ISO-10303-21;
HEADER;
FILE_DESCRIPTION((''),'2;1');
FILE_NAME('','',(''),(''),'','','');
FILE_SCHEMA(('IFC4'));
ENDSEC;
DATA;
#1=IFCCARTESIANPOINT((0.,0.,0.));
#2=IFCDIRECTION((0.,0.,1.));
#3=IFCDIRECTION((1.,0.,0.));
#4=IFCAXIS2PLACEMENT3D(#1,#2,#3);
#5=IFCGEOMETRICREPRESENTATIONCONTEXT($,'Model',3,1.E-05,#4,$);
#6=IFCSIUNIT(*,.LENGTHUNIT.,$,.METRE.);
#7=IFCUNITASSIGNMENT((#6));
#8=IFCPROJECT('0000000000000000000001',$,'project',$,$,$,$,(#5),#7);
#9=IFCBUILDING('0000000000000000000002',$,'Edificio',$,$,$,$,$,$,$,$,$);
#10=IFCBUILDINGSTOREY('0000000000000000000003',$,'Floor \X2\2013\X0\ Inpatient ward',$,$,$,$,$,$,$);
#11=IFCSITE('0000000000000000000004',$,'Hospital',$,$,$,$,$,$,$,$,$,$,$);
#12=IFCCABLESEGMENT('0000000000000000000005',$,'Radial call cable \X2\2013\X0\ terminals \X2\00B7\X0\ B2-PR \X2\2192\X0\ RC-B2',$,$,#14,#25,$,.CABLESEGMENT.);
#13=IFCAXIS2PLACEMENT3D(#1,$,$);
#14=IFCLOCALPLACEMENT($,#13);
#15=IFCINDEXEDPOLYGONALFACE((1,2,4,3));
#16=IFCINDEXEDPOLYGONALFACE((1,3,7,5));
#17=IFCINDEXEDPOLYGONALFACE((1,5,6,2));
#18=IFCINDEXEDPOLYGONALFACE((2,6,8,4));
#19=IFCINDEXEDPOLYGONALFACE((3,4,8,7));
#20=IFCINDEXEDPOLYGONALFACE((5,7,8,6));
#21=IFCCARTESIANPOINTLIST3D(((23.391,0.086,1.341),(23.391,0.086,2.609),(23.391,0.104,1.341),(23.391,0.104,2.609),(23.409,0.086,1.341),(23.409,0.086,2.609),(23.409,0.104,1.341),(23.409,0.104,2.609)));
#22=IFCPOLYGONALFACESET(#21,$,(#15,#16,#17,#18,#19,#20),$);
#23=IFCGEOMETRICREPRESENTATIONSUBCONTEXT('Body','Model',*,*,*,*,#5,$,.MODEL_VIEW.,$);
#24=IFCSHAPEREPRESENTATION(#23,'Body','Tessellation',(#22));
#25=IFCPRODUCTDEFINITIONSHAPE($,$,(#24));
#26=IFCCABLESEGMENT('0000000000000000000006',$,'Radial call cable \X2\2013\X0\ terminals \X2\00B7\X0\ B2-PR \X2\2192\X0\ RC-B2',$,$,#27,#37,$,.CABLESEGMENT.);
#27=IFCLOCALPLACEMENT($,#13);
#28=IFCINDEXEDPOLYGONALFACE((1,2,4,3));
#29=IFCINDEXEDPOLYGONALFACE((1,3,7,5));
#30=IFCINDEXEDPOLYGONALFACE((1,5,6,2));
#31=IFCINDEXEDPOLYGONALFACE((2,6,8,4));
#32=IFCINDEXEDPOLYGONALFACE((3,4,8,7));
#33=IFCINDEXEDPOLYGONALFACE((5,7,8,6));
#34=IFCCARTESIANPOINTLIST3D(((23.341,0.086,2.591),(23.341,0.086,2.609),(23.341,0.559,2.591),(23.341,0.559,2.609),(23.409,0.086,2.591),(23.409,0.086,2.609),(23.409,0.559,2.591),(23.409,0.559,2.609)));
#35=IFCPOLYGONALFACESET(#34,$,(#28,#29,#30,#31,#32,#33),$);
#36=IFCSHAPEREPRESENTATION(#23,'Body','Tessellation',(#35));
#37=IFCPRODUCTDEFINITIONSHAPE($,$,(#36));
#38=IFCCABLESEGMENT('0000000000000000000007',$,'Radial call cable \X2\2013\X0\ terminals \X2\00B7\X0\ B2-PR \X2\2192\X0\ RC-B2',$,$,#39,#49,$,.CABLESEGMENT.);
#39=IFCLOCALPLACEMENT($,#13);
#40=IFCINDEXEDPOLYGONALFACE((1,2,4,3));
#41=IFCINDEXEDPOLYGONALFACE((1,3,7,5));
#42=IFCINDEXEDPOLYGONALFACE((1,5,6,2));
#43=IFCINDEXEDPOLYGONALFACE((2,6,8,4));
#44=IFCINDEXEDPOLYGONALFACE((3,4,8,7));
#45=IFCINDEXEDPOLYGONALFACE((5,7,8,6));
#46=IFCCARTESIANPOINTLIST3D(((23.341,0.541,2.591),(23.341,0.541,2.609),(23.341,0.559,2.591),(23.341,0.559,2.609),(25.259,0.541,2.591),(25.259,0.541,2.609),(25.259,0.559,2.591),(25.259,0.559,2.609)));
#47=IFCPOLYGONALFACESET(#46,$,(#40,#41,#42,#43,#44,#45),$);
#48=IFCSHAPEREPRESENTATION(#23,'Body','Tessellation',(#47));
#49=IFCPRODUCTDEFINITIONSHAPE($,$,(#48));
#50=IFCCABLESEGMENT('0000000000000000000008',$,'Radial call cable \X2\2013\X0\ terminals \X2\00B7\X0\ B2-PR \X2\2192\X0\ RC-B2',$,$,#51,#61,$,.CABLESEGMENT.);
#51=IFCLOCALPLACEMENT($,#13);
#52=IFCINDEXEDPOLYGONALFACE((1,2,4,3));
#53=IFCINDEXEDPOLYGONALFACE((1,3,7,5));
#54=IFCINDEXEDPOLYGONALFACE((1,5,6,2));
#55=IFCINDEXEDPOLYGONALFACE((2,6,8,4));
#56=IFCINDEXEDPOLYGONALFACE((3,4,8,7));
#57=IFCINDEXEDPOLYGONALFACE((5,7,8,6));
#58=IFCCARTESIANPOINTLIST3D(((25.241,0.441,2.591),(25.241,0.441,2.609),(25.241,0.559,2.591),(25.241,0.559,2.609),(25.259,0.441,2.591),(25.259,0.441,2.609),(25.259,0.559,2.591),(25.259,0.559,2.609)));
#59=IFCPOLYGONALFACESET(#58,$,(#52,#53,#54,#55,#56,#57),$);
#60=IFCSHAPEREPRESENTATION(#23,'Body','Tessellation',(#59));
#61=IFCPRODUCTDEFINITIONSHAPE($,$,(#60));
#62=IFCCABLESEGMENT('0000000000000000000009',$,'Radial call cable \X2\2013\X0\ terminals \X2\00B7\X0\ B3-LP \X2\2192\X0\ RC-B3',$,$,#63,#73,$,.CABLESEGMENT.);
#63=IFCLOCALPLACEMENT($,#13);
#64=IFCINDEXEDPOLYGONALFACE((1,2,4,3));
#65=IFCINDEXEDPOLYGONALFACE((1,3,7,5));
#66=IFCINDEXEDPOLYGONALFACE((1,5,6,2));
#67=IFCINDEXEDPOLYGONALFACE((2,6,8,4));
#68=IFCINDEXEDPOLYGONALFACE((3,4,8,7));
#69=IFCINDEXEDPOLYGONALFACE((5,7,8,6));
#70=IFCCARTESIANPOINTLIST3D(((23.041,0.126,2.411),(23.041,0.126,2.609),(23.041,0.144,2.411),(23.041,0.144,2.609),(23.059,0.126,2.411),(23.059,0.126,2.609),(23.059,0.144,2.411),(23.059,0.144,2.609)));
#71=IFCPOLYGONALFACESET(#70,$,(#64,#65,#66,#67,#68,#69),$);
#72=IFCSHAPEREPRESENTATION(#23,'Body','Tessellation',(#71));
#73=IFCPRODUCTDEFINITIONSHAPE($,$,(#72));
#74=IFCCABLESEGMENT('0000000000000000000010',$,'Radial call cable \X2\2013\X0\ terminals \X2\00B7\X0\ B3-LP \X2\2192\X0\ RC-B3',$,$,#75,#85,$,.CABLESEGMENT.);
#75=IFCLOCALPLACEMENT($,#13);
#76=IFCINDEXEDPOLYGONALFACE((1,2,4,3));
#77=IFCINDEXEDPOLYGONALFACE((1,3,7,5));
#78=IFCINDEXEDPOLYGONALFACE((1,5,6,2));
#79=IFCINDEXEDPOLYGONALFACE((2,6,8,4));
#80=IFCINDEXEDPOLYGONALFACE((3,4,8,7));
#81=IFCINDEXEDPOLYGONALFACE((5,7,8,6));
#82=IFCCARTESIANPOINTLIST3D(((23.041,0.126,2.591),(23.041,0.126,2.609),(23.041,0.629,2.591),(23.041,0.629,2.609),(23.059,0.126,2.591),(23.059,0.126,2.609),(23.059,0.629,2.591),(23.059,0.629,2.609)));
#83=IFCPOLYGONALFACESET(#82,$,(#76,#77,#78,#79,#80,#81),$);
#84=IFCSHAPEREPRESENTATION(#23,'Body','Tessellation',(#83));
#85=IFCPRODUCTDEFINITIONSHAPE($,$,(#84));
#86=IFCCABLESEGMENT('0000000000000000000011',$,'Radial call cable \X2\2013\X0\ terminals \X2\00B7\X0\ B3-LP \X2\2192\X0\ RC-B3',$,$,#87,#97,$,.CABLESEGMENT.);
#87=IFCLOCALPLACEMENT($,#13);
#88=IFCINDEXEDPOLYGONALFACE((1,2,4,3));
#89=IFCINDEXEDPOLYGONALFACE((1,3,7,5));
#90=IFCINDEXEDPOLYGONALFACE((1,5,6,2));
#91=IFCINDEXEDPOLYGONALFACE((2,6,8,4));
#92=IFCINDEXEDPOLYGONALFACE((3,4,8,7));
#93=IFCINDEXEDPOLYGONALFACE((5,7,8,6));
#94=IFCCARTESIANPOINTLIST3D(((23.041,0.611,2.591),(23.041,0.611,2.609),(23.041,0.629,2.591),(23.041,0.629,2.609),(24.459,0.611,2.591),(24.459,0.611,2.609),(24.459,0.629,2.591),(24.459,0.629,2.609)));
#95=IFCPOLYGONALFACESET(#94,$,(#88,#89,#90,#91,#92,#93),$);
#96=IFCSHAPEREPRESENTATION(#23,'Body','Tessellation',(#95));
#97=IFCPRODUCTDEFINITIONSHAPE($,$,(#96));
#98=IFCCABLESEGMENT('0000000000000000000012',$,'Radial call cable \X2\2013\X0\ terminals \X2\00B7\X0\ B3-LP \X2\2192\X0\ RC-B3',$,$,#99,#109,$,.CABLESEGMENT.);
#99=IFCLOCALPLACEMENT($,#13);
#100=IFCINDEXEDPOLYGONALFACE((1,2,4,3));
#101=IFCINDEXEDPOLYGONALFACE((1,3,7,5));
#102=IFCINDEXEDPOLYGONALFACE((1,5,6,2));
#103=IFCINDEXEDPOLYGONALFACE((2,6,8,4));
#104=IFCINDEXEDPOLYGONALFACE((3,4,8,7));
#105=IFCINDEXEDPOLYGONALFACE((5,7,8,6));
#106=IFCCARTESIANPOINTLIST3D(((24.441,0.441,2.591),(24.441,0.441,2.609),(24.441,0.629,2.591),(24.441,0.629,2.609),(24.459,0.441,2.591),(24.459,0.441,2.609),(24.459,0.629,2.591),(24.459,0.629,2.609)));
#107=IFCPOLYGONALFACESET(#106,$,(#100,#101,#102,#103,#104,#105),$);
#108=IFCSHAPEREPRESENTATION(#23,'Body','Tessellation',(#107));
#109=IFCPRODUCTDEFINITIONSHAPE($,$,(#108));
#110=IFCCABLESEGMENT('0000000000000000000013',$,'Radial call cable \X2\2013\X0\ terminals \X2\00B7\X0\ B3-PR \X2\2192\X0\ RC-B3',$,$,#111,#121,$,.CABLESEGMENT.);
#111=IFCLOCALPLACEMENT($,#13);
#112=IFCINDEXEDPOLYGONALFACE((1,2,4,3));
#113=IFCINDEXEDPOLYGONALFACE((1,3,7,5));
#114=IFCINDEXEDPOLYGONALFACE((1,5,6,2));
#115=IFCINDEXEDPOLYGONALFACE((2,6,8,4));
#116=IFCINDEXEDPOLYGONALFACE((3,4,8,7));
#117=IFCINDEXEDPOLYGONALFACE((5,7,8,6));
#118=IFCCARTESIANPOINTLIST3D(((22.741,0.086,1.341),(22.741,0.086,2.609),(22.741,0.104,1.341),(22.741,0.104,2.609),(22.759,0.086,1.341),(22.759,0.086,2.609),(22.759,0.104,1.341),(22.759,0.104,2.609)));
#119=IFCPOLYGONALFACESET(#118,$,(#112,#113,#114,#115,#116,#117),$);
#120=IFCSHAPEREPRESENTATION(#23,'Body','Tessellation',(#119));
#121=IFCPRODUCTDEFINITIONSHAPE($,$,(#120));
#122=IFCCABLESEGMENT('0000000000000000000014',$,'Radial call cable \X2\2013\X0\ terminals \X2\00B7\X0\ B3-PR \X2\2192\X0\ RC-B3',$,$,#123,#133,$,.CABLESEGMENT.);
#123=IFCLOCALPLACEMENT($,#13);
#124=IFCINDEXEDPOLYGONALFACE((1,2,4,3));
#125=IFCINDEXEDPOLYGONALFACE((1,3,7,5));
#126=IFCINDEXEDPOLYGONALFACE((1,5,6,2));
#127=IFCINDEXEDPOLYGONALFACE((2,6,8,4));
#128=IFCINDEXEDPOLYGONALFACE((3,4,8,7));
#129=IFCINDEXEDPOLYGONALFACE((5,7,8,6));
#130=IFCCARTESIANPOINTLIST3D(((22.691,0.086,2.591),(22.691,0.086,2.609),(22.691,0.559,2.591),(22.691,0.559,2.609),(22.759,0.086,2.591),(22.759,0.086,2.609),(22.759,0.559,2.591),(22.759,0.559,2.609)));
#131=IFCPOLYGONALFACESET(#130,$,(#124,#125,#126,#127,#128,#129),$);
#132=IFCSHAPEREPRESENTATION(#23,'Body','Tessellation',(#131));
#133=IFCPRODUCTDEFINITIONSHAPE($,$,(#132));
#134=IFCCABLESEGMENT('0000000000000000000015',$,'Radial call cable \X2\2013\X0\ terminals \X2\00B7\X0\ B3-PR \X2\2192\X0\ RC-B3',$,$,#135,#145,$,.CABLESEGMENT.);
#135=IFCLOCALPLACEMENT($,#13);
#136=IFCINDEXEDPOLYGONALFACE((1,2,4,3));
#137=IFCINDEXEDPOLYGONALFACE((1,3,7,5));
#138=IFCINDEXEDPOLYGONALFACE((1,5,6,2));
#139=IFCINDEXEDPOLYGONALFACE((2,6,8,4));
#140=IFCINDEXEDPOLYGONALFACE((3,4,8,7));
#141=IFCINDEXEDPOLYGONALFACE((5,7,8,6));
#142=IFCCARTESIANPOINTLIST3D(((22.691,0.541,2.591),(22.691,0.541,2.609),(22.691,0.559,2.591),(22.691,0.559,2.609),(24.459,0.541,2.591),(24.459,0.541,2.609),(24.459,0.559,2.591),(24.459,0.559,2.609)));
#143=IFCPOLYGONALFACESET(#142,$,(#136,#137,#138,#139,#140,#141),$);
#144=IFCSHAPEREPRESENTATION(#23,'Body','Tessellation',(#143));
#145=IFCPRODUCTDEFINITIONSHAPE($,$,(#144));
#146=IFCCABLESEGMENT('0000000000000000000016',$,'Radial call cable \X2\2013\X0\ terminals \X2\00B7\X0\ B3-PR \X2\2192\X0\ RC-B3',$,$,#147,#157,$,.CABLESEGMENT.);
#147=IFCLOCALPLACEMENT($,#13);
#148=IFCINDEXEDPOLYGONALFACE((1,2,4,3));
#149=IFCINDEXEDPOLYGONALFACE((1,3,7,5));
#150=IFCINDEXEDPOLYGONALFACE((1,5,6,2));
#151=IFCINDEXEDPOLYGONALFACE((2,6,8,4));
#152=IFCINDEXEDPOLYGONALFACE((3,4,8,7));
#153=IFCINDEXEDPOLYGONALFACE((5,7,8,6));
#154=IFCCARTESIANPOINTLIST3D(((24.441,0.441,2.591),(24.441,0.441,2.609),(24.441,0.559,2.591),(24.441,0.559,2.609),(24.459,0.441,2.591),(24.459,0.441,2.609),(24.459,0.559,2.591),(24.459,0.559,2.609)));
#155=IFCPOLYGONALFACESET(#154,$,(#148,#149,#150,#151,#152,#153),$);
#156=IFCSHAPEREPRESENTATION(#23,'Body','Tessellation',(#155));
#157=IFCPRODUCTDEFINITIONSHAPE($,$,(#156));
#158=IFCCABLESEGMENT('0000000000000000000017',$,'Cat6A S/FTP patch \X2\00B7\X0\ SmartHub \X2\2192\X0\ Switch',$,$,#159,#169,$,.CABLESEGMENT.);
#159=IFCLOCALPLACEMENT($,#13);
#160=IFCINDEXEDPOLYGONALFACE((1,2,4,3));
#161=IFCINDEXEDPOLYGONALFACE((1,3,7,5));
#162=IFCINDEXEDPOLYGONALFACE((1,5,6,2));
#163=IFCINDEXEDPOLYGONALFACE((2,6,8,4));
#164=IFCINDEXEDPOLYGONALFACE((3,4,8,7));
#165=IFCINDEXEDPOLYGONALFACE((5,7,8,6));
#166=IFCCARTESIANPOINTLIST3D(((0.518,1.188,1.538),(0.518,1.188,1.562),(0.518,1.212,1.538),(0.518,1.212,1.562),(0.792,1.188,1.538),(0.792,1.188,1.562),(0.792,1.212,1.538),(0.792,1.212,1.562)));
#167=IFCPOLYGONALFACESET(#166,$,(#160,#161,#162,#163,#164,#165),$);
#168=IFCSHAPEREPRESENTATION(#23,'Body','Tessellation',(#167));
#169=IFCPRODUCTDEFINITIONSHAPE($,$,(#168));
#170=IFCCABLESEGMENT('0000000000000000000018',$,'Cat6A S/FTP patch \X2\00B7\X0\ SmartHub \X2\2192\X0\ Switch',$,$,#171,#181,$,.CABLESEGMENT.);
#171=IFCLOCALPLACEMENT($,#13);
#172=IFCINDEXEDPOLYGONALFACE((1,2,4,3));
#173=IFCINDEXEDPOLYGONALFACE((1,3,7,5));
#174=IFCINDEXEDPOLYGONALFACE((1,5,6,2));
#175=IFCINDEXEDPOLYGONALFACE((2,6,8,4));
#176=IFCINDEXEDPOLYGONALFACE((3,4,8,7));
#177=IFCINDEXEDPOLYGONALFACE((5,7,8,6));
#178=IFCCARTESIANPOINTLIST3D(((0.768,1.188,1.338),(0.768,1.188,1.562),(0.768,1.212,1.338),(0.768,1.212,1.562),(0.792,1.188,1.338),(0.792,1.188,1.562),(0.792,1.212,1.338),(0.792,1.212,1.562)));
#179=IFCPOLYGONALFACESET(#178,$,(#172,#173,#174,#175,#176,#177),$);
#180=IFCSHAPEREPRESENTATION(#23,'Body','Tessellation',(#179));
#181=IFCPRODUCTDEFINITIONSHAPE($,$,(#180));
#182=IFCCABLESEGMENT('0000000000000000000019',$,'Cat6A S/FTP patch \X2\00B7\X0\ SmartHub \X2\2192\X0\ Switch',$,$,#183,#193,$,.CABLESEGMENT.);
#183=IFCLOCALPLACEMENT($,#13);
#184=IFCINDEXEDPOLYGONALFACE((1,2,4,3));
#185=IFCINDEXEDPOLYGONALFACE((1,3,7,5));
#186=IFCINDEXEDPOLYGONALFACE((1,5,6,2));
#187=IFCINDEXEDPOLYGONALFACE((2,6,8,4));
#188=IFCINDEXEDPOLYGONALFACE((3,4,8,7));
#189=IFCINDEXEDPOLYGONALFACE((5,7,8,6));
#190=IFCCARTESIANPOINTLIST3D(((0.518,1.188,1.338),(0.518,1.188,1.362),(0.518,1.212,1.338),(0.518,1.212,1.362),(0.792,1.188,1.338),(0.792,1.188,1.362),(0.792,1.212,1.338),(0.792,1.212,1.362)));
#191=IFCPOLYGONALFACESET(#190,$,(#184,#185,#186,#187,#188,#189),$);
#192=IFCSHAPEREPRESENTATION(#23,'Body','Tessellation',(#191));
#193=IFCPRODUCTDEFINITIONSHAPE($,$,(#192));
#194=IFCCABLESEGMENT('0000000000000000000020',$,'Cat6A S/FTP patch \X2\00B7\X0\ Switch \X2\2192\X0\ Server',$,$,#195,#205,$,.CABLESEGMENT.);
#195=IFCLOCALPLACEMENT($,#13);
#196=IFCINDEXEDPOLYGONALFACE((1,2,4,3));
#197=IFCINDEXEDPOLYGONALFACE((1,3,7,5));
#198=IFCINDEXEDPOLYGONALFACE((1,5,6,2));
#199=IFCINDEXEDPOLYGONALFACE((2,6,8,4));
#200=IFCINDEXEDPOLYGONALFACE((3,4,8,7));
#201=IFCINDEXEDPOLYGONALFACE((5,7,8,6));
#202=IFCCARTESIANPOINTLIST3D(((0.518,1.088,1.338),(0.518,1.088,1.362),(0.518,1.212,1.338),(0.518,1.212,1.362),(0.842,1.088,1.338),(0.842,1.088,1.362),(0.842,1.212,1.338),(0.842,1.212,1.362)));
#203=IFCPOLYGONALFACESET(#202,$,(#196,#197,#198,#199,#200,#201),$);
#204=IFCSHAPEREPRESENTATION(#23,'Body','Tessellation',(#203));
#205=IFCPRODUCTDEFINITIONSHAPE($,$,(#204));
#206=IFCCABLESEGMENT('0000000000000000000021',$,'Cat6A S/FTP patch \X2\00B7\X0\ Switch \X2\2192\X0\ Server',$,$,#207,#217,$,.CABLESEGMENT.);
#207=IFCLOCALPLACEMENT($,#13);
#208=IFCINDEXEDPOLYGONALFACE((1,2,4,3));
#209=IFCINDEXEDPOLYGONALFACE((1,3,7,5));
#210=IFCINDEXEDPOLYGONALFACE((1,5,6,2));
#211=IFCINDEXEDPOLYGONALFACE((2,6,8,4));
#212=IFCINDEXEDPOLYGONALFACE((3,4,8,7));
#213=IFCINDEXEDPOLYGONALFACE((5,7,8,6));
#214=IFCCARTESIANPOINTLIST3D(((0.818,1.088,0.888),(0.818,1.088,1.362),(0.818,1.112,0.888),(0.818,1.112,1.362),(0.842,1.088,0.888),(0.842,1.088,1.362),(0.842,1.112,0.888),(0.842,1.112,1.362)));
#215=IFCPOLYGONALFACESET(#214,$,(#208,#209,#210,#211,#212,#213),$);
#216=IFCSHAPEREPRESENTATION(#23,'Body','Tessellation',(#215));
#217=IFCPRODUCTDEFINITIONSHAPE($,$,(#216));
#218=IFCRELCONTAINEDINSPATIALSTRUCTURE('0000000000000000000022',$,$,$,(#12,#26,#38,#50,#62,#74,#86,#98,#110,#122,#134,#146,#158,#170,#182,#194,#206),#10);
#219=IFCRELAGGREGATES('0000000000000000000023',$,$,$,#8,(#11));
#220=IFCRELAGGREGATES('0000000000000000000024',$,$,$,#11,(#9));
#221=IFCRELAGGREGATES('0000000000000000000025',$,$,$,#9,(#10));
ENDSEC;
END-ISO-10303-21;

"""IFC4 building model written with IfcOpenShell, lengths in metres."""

from ifc_helpers import new_model, si_unit, frame, origin_with_axes, context, subcontext, project, spatial, line, indexed_curve, outline, extrude, element, save


model = new_model("IFC4")

# Units and contexts
model_context = context("Model", 3, precision=1e-05, world=origin_with_axes())
body_context = subcontext(model_context, "Body", "Model", "MODEL_VIEW")
ifc_project = project(units=[si_unit("LENGTHUNIT", "METRE")], contexts=[model_context])

# Site, building, storey
site = spatial("IfcSite", under=ifc_project, Name="Hospital")
building = spatial("IfcBuilding", under=site, Name="Edificio")
storey = spatial("IfcBuildingStorey", under=building, Name="Floor – Inpatient ward")

# Cable segments
element("IfcCableSegment", 1, inside=storey, Name="Radial call cable – terminals · B2-PR → RC-B2", PredefinedType="CABLESEGMENT", context=body_context, shape_type="SweptSolid", body=[
    extrude(outline(indexed_curve([(0.0, 0.0), (0.018, 0.0), (0.018, 0.018), (0.0, 0.018)], segments=[line(1, 2, 3, 4, 1)])), frame((23.391, 0.086, 1.341), z_axis=(0.0, 0.0, 1.0), x_axis=(1.0, 0.0, 0.0)), (0.0, 0.0, 1.0), 1.268),
])
element("IfcCableSegment", 2, inside=storey, Name="Radial call cable – terminals · B2-PR → RC-B2", PredefinedType="CABLESEGMENT", context=body_context, shape_type="SweptSolid", body=[
    extrude(outline(indexed_curve([(0.0, 0.0), (0.068, 0.0), (0.068, 0.473), (0.0, 0.473)], segments=[line(1, 2, 3, 4, 1)])), frame((23.341, 0.086, 2.591), z_axis=(0.0, 0.0, 1.0), x_axis=(1.0, 0.0, 0.0)), (0.0, 0.0, 1.0), 0.018),
])
element("IfcCableSegment", 3, inside=storey, Name="Radial call cable – terminals · B2-PR → RC-B2", PredefinedType="CABLESEGMENT", context=body_context, shape_type="SweptSolid", body=[
    extrude(outline(indexed_curve([(0.0, 0.0), (1.918, 0.0), (1.918, 0.018), (0.0, 0.018)], segments=[line(1, 2, 3, 4, 1)])), frame((23.341, 0.541, 2.591), z_axis=(0.0, 0.0, 1.0), x_axis=(1.0, 0.0, 0.0)), (0.0, 0.0, 1.0), 0.018),
])
element("IfcCableSegment", 4, inside=storey, Name="Radial call cable – terminals · B2-PR → RC-B2", PredefinedType="CABLESEGMENT", context=body_context, shape_type="SweptSolid", body=[
    extrude(outline(indexed_curve([(0.0, 0.0), (0.018, 0.0), (0.018, 0.118), (0.0, 0.118)], segments=[line(1, 2, 3, 4, 1)])), frame((25.241, 0.441, 2.591), z_axis=(0.0, 0.0, 1.0), x_axis=(1.0, 0.0, 0.0)), (0.0, 0.0, 1.0), 0.018),
])
element("IfcCableSegment", 5, inside=storey, Name="Radial call cable – terminals · B3-LP → RC-B3", PredefinedType="CABLESEGMENT", context=body_context, shape_type="SweptSolid", body=[
    extrude(outline(indexed_curve([(0.0, 0.0), (0.018, 0.0), (0.018, 0.018), (0.0, 0.018)], segments=[line(1, 2, 3, 4, 1)])), frame((23.041, 0.126, 2.411), z_axis=(0.0, 0.0, 1.0), x_axis=(1.0, 0.0, 0.0)), (0.0, 0.0, 1.0), 0.198),
])
element("IfcCableSegment", 6, inside=storey, Name="Radial call cable – terminals · B3-LP → RC-B3", PredefinedType="CABLESEGMENT", context=body_context, shape_type="SweptSolid", body=[
    extrude(outline(indexed_curve([(0.0, 0.0), (0.018, 0.0), (0.018, 0.503), (0.0, 0.503)], segments=[line(1, 2, 3, 4, 1)])), frame((23.041, 0.126, 2.591), z_axis=(0.0, 0.0, 1.0), x_axis=(1.0, 0.0, 0.0)), (0.0, 0.0, 1.0), 0.018),
])
element("IfcCableSegment", 7, inside=storey, Name="Radial call cable – terminals · B3-LP → RC-B3", PredefinedType="CABLESEGMENT", context=body_context, shape_type="SweptSolid", body=[
    extrude(outline(indexed_curve([(0.0, 0.0), (1.418, 0.0), (1.418, 0.018), (0.0, 0.018)], segments=[line(1, 2, 3, 4, 1)])), frame((23.041, 0.611, 2.591), z_axis=(0.0, 0.0, 1.0), x_axis=(1.0, 0.0, 0.0)), (0.0, 0.0, 1.0), 0.018),
])
element("IfcCableSegment", 8, inside=storey, Name="Radial call cable – terminals · B3-LP → RC-B3", PredefinedType="CABLESEGMENT", context=body_context, shape_type="SweptSolid", body=[
    extrude(outline(indexed_curve([(0.0, 0.0), (0.018, 0.0), (0.018, 0.188), (0.0, 0.188)], segments=[line(1, 2, 3, 4, 1)])), frame((24.441, 0.441, 2.591), z_axis=(0.0, 0.0, 1.0), x_axis=(1.0, 0.0, 0.0)), (0.0, 0.0, 1.0), 0.018),
])
element("IfcCableSegment", 9, inside=storey, Name="Radial call cable – terminals · B3-PR → RC-B3", PredefinedType="CABLESEGMENT", context=body_context, shape_type="SweptSolid", body=[
    extrude(outline(indexed_curve([(0.0, 0.0), (0.018, 0.0), (0.018, 0.018), (0.0, 0.018)], segments=[line(1, 2, 3, 4, 1)])), frame((22.741, 0.086, 1.341), z_axis=(0.0, 0.0, 1.0), x_axis=(1.0, 0.0, 0.0)), (0.0, 0.0, 1.0), 1.268),
])
element("IfcCableSegment", 10, inside=storey, Name="Radial call cable – terminals · B3-PR → RC-B3", PredefinedType="CABLESEGMENT", context=body_context, shape_type="SweptSolid", body=[
    extrude(outline(indexed_curve([(0.0, 0.0), (0.068, 0.0), (0.068, 0.473), (0.0, 0.473)], segments=[line(1, 2, 3, 4, 1)])), frame((22.691, 0.086, 2.591), z_axis=(0.0, 0.0, 1.0), x_axis=(1.0, 0.0, 0.0)), (0.0, 0.0, 1.0), 0.018),
])
element("IfcCableSegment", 11, inside=storey, Name="Radial call cable – terminals · B3-PR → RC-B3", PredefinedType="CABLESEGMENT", context=body_context, shape_type="SweptSolid", body=[
    extrude(outline(indexed_curve([(0.0, 0.0), (1.768, 0.0), (1.768, 0.018), (0.0, 0.018)], segments=[line(1, 2, 3, 4, 1)])), frame((22.691, 0.541, 2.591), z_axis=(0.0, 0.0, 1.0), x_axis=(1.0, 0.0, 0.0)), (0.0, 0.0, 1.0), 0.018),
])
element("IfcCableSegment", 12, inside=storey, Name="Radial call cable – terminals · B3-PR → RC-B3", PredefinedType="CABLESEGMENT", context=body_context, shape_type="SweptSolid", body=[
    extrude(outline(indexed_curve([(0.0, 0.0), (0.018, 0.0), (0.018, 0.118), (0.0, 0.118)], segments=[line(1, 2, 3, 4, 1)])), frame((24.441, 0.441, 2.591), z_axis=(0.0, 0.0, 1.0), x_axis=(1.0, 0.0, 0.0)), (0.0, 0.0, 1.0), 0.018),
])
element("IfcCableSegment", 13, inside=storey, Name="Cat6A S/FTP patch · SmartHub → Switch", PredefinedType="CABLESEGMENT", context=body_context, shape_type="SweptSolid", body=[
    extrude(outline(indexed_curve([(0.0, 0.0), (0.274, 0.0), (0.274, 0.024), (0.0, 0.024)], segments=[line(1, 2, 3, 4, 1)])), frame((0.518, 1.188, 1.538), z_axis=(0.0, 0.0, 1.0), x_axis=(1.0, 0.0, 0.0)), (0.0, 0.0, 1.0), 0.024),
])
element("IfcCableSegment", 14, inside=storey, Name="Cat6A S/FTP patch · SmartHub → Switch", PredefinedType="CABLESEGMENT", context=body_context, shape_type="SweptSolid", body=[
    extrude(outline(indexed_curve([(0.0, 0.0), (0.024, 0.0), (0.024, 0.024), (0.0, 0.024)], segments=[line(1, 2, 3, 4, 1)])), frame((0.768, 1.188, 1.338), z_axis=(0.0, 0.0, 1.0), x_axis=(1.0, 0.0, 0.0)), (0.0, 0.0, 1.0), 0.224),
])
element("IfcCableSegment", 15, inside=storey, Name="Cat6A S/FTP patch · SmartHub → Switch", PredefinedType="CABLESEGMENT", context=body_context, shape_type="SweptSolid", body=[
    extrude(outline(indexed_curve([(0.0, 0.0), (0.274, 0.0), (0.274, 0.024), (0.0, 0.024)], segments=[line(1, 2, 3, 4, 1)])), frame((0.518, 1.188, 1.338), z_axis=(0.0, 0.0, 1.0), x_axis=(1.0, 0.0, 0.0)), (0.0, 0.0, 1.0), 0.024),
])
element("IfcCableSegment", 16, inside=storey, Name="Cat6A S/FTP patch · Switch → Server", PredefinedType="CABLESEGMENT", context=body_context, shape_type="SweptSolid", body=[
    extrude(outline(indexed_curve([(0.0, 0.0), (0.324, 0.0), (0.324, 0.124), (0.0, 0.124)], segments=[line(1, 2, 3, 4, 1)])), frame((0.518, 1.088, 1.338), z_axis=(0.0, 0.0, 1.0), x_axis=(1.0, 0.0, 0.0)), (0.0, 0.0, 1.0), 0.024),
])
element("IfcCableSegment", 17, inside=storey, Name="Cat6A S/FTP patch · Switch → Server", PredefinedType="CABLESEGMENT", context=body_context, shape_type="SweptSolid", body=[
    extrude(outline(indexed_curve([(0.0, 0.0), (0.024, 0.0), (0.024, 0.024), (0.0, 0.024)], segments=[line(1, 2, 3, 4, 1)])), frame((0.818, 1.088, 0.888), z_axis=(0.0, 0.0, 1.0), x_axis=(1.0, 0.0, 0.0)), (0.0, 0.0, 1.0), 0.474),
])

save(model, "model.ifc")
